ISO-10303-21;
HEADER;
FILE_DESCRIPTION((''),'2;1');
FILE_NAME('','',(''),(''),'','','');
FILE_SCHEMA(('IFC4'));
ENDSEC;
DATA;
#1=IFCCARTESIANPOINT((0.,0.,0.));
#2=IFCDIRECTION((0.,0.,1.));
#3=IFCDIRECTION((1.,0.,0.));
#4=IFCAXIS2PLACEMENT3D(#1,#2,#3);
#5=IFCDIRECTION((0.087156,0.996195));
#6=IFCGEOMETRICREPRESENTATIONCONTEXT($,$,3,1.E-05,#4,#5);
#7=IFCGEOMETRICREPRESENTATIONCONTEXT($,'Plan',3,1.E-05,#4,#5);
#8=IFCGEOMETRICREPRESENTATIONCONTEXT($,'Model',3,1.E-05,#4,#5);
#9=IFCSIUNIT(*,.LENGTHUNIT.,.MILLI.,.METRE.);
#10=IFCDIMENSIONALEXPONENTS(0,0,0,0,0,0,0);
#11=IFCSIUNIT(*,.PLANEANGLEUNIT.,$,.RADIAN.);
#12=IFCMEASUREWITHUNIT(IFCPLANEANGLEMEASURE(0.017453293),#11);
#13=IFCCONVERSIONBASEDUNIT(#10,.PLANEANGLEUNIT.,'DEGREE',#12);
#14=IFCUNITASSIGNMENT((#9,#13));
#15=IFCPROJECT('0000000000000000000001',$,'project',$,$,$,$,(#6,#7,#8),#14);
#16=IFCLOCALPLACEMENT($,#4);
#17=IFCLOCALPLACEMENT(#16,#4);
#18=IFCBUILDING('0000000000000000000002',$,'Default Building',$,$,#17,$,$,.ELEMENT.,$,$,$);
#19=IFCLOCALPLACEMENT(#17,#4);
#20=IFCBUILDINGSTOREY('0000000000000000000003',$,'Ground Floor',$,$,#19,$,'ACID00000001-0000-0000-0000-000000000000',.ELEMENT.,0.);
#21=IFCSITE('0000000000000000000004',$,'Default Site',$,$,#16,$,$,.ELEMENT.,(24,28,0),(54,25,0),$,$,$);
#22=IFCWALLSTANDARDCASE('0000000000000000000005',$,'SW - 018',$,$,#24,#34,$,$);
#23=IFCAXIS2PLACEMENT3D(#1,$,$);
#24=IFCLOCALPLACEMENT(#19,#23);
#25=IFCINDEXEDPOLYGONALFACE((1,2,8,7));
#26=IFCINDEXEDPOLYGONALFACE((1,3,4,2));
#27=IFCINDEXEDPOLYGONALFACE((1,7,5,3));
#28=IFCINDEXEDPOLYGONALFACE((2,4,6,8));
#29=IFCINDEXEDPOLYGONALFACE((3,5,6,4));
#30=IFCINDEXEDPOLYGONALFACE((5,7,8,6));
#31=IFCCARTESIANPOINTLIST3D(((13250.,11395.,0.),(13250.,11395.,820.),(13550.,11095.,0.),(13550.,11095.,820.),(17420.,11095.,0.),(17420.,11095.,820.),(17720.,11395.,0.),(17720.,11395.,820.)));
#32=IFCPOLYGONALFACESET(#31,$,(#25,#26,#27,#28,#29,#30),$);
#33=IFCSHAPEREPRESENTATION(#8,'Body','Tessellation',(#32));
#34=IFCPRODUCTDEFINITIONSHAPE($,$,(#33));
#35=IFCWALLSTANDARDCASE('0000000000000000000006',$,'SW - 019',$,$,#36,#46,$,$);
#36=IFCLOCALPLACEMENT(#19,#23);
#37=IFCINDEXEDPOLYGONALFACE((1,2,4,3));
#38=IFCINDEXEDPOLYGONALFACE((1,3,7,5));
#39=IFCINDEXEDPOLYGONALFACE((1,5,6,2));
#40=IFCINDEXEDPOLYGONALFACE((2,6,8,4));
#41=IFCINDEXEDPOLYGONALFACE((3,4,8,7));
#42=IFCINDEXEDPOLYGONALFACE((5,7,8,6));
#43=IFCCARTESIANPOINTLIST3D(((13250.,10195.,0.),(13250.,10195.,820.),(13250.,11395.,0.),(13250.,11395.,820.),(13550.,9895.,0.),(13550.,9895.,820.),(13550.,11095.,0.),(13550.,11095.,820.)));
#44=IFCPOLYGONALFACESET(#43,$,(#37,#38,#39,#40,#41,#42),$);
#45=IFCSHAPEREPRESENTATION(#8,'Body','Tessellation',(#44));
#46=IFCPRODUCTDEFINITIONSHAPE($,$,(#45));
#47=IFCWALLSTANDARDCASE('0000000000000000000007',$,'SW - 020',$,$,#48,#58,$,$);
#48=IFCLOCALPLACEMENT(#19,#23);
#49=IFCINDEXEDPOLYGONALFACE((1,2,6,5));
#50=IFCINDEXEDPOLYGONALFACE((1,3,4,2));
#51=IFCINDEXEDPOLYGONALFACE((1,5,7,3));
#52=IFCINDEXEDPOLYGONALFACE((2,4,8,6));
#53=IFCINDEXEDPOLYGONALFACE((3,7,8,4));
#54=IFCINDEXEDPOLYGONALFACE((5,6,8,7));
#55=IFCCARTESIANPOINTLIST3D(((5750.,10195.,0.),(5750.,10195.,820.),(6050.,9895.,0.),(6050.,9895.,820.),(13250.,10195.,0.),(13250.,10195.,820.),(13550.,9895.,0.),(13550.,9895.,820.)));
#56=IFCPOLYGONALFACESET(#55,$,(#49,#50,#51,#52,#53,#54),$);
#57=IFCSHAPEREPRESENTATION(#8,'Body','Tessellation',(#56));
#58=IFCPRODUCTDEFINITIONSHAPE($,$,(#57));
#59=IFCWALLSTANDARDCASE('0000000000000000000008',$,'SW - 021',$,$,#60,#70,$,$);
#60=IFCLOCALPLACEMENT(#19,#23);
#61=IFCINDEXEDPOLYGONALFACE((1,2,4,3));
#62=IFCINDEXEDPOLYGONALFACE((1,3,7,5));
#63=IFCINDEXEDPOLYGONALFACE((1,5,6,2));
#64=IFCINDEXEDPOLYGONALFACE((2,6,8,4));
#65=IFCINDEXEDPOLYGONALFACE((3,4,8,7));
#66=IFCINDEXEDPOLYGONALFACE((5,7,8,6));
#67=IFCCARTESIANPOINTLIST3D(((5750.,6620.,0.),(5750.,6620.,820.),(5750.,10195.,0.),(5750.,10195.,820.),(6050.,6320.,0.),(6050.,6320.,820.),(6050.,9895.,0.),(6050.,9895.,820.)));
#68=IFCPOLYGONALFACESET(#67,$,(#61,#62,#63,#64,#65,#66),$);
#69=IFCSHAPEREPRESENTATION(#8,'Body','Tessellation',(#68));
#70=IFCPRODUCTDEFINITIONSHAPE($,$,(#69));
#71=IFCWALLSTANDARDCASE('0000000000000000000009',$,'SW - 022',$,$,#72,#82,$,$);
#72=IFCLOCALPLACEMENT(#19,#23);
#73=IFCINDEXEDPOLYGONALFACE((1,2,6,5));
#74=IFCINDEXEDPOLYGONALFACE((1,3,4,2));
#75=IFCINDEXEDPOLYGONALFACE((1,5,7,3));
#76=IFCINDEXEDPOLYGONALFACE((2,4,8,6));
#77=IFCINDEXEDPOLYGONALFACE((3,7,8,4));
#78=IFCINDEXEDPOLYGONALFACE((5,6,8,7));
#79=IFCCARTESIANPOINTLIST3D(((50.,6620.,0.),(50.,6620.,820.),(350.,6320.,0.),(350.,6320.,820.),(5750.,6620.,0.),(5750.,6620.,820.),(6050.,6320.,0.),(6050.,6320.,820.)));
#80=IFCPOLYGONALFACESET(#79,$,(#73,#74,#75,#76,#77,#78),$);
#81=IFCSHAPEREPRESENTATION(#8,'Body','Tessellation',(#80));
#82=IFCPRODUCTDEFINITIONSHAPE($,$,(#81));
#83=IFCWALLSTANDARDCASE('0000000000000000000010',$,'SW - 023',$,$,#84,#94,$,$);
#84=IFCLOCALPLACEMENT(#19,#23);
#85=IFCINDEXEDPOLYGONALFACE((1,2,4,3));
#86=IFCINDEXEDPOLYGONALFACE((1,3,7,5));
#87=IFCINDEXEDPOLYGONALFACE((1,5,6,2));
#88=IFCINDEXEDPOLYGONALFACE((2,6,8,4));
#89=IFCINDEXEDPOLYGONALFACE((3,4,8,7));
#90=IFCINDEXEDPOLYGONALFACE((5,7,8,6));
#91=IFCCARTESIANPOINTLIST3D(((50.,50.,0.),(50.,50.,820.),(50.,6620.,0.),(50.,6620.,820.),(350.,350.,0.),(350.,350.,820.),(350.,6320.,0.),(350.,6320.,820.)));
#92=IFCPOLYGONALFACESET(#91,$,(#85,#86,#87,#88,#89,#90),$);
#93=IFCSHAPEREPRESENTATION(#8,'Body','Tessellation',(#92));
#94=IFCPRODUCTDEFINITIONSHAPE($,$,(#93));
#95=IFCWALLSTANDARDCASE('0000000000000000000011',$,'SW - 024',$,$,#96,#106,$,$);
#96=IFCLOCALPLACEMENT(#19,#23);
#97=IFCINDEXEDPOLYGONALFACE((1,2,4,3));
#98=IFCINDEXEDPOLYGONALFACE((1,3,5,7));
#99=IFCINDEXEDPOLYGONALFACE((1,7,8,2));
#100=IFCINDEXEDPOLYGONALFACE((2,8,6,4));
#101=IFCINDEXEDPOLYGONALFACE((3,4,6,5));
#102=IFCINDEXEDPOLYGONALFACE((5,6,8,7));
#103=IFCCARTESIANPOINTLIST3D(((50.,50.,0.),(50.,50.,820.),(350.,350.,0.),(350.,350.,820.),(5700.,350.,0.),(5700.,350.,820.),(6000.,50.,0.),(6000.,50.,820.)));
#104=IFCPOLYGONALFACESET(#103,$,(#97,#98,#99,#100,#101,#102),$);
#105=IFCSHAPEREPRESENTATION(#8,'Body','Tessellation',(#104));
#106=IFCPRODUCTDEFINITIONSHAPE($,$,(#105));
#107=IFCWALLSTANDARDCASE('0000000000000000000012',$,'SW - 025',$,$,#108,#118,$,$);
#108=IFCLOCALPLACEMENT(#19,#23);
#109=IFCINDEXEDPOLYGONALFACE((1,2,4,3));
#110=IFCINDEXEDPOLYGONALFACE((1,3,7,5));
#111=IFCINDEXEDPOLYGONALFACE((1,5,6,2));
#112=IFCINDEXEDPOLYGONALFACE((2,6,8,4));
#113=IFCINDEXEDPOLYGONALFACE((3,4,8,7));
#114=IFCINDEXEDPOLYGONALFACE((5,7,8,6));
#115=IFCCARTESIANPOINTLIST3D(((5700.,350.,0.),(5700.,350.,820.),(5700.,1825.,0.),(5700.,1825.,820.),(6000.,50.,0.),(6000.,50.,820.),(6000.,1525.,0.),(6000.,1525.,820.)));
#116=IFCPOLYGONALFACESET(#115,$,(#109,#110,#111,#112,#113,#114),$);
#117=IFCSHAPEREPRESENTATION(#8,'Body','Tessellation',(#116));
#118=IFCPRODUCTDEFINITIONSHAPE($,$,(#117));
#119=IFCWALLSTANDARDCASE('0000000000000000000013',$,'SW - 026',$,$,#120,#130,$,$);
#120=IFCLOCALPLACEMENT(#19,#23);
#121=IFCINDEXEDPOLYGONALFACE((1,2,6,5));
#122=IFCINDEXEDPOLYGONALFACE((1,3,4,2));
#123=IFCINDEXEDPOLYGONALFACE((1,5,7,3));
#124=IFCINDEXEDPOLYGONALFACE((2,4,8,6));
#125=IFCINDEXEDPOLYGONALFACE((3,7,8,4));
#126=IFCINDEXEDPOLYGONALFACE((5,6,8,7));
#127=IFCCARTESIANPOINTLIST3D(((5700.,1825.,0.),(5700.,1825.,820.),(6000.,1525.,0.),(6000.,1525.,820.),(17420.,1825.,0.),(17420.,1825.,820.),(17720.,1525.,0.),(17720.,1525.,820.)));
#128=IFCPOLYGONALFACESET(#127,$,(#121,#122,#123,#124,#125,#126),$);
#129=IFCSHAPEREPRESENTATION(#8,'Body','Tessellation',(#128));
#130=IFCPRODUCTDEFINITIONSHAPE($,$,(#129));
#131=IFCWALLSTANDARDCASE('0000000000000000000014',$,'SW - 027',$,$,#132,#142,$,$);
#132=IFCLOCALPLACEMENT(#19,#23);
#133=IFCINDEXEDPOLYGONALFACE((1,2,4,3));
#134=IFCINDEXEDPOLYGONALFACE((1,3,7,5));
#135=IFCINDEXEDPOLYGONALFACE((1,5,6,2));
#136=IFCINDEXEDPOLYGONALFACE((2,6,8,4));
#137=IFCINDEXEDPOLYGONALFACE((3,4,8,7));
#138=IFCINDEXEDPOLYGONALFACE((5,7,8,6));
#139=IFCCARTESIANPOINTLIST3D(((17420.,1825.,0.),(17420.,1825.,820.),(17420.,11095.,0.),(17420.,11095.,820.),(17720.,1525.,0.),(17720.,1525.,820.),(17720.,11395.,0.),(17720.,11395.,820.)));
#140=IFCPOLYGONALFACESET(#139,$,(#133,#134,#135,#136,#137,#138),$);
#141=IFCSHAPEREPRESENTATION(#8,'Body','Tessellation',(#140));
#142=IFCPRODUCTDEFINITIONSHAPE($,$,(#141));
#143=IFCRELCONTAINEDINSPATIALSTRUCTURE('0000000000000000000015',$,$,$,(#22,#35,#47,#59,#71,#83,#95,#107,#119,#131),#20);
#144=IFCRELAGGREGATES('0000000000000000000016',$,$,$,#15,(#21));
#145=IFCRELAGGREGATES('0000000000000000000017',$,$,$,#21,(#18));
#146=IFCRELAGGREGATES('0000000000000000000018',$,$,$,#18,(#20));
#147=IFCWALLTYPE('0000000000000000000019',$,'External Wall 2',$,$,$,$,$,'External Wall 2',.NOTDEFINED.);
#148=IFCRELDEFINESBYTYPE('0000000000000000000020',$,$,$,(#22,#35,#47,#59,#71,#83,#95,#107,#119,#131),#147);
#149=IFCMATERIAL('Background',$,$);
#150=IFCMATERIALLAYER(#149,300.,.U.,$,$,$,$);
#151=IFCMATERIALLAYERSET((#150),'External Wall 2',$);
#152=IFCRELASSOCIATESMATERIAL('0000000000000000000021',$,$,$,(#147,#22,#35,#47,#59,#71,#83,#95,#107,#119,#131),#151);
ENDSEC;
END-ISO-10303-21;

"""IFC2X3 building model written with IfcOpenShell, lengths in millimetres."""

from ifc_helpers import new_model, entity, si_unit, converted_unit, direction, frame, origin_with_axes, place, context, project, spatial, polyline, outline, extrude, material, layer, layer_set, layer_usage, type_object, element, save


model = new_model("IFC2X3")

# Units and contexts
context_of_model = context(None, 3, precision=1e-05, world=origin_with_axes(), true_north=direction((0.087156, 0.996195)))
plan_context = context("Plan", 3, precision=1e-05, world=origin_with_axes(), true_north=direction((0.087156, 0.996195)))
model_context = context("Model", 3, precision=1e-05, world=origin_with_axes(), true_north=direction((0.087156, 0.996195)))
ifc_project = project(units=[si_unit("LENGTHUNIT", "METRE", prefix="MILLI"), converted_unit("PLANEANGLEUNIT", "DEGREE", entity("IfcPlaneAngleMeasure", 0.017453293), si_unit("PLANEANGLEUNIT", "RADIAN"), dimensions=[0, 0, 0, 0, 0, 0, 0])], contexts=[context_of_model, plan_context, model_context])

# Site, building, storey
site_placement = place(None, origin_with_axes())
site = spatial("IfcSite", under=ifc_project, at=site_placement, Name="Default Site", CompositionType="ELEMENT", RefLatitude=(24, 28, 0), RefLongitude=(54, 25, 0))
building_placement = place(site_placement, origin_with_axes())
building = spatial("IfcBuilding", under=site, at=building_placement, Name="Default Building", CompositionType="ELEMENT")
storey_placement = place(building_placement, origin_with_axes())
storey = spatial("IfcBuildingStorey", under=building, at=storey_placement, Name="Ground Floor", LongName="ACID00000001-0000-0000-0000-000000000000", CompositionType="ELEMENT", Elevation=0.0)

# Walls
ifc_material = material(Name="Background")
ifc_layer = layer(ifc_material, 300.0, ventilated="UNKNOWN")
ifc_layer_set = layer_set([ifc_layer], Name="External Wall 2")
ifc_layer_usage_1 = layer_usage(ifc_layer_set, "AXIS2", "POSITIVE", 0.0)
wall_type = type_object("IfcWallType", Name="External Wall 2", ElementType="External Wall 2", PredefinedType="NOTDEFINED", material=ifc_layer_set)
wall_1_placement = place(storey_placement, frame((17720.0, 11395.0, 0.0), z_axis=(0.0, 0.0, 1.0), x_axis=(-1.0, 0.0, 0.0)))
element("IfcWallStandardCase", 1, at=wall_1_placement, inside=storey, type_object=wall_type, material=ifc_layer_usage_1, Name="SW - 018", context=model_context, shape_type="SweptSolid", body=[
    extrude(outline(polyline([(0.0, 0.0), (4470.0, 0.0), (4170.0, 300.0), (300.0, 300.0), (0.0, 0.0)])), origin_with_axes(), (0.0, 0.0, 1.0), 820.0),
])
ifc_layer_usage_2 = layer_usage(ifc_layer_set, "AXIS2", "POSITIVE", 0.0)
wall_2_placement = place(storey_placement, frame((13250.0, 11395.0, 0.0), z_axis=(0.0, 0.0, 1.0), x_axis=(0.0, -1.0, 0.0)))
element("IfcWallStandardCase", 2, at=wall_2_placement, inside=storey, type_object=wall_type, material=ifc_layer_usage_2, Name="SW - 019", context=model_context, shape_type="SweptSolid", body=[
    extrude(outline(polyline([(0.0, 0.0), (1200.0, 0.0), (1500.0, 300.0), (300.0, 300.0), (0.0, 0.0)])), origin_with_axes(), (0.0, 0.0, 1.0), 820.0),
])
ifc_layer_usage_3 = layer_usage(ifc_layer_set, "AXIS2", "POSITIVE", 0.0)
wall_3_placement = place(storey_placement, frame((13250.0, 10195.0, 0.0), z_axis=(0.0, 0.0, 1.0), x_axis=(-1.0, 0.0, 0.0)))
element("IfcWallStandardCase", 3, at=wall_3_placement, inside=storey, type_object=wall_type, material=ifc_layer_usage_3, Name="SW - 020", context=model_context, shape_type="SweptSolid", body=[
    extrude(outline(polyline([(0.0, 0.0), (7500.0, 0.0), (7200.0, 300.0), (-300.0, 300.0), (0.0, 0.0)])), origin_with_axes(), (0.0, 0.0, 1.0), 820.0),
])
ifc_layer_usage_4 = layer_usage(ifc_layer_set, "AXIS2", "POSITIVE", 0.0)
wall_4_placement = place(storey_placement, frame((5750.0, 10195.0, 0.0), z_axis=(0.0, 0.0, 1.0), x_axis=(0.0, -1.0, 0.0)))
element("IfcWallStandardCase", 4, at=wall_4_placement, inside=storey, type_object=wall_type, material=ifc_layer_usage_4, Name="SW - 021", context=model_context, shape_type="SweptSolid", body=[
    extrude(outline(polyline([(0.0, 0.0), (3575.0, 0.0), (3875.0, 300.0), (300.0, 300.0), (0.0, 0.0)])), origin_with_axes(), (0.0, 0.0, 1.0), 820.0),
])
ifc_layer_usage_5 = layer_usage(ifc_layer_set, "AXIS2", "POSITIVE", 0.0)
wall_5_placement = place(storey_placement, frame((5750.0, 6620.0, 0.0), z_axis=(0.0, 0.0, 1.0), x_axis=(-1.0, 0.0, 0.0)))
element("IfcWallStandardCase", 5, at=wall_5_placement, inside=storey, type_object=wall_type, material=ifc_layer_usage_5, Name="SW - 022", context=model_context, shape_type="SweptSolid", body=[
    extrude(outline(polyline([(0.0, 0.0), (5700.0, 0.0), (5400.0, 300.0), (-300.0, 300.0), (0.0, 0.0)])), origin_with_axes(), (0.0, 0.0, 1.0), 820.0),
])
ifc_layer_usage_6 = layer_usage(ifc_layer_set, "AXIS2", "POSITIVE", 0.0)
wall_6_placement = place(storey_placement, frame((50.0, 6620.0, 0.0), z_axis=(0.0, 0.0, 1.0), x_axis=(0.0, -1.0, 0.0)))
element("IfcWallStandardCase", 6, at=wall_6_placement, inside=storey, type_object=wall_type, material=ifc_layer_usage_6, Name="SW - 023", context=model_context, shape_type="SweptSolid", body=[
    extrude(outline(polyline([(0.0, 0.0), (6570.0, 0.0), (6270.0, 300.0), (300.0, 300.0), (0.0, 0.0)])), origin_with_axes(), (0.0, 0.0, 1.0), 820.0),
])
ifc_layer_usage_7 = layer_usage(ifc_layer_set, "AXIS2", "POSITIVE", 0.0)
wall_7_placement = place(storey_placement, frame((50.0, 50.0, 0.0), z_axis=(0.0, 0.0, 1.0), x_axis=(1.0, 0.0, 0.0)))
element("IfcWallStandardCase", 7, at=wall_7_placement, inside=storey, type_object=wall_type, material=ifc_layer_usage_7, Name="SW - 024", context=model_context, shape_type="SweptSolid", body=[
    extrude(outline(polyline([(0.0, 0.0), (5950.0, 0.0), (5650.0, 300.0), (300.0, 300.0), (0.0, 0.0)])), origin_with_axes(), (0.0, 0.0, 1.0), 820.0),
])
ifc_layer_usage_8 = layer_usage(ifc_layer_set, "AXIS2", "POSITIVE", 0.0)
wall_8_placement = place(storey_placement, frame((6000.0, 50.0, 0.0), z_axis=(0.0, 0.0, 1.0), x_axis=(0.0, 1.0, 0.0)))
element("IfcWallStandardCase", 8, at=wall_8_placement, inside=storey, type_object=wall_type, material=ifc_layer_usage_8, Name="SW - 025", context=model_context, shape_type="SweptSolid", body=[
    extrude(outline(polyline([(0.0, 0.0), (1475.0, 0.0), (1775.0, 300.0), (300.0, 300.0), (0.0, 0.0)])), origin_with_axes(), (0.0, 0.0, 1.0), 820.0),
])
ifc_layer_usage_9 = layer_usage(ifc_layer_set, "AXIS2", "POSITIVE", 0.0)
wall_9_placement = place(storey_placement, frame((6000.0, 1525.0, 0.0), z_axis=(0.0, 0.0, 1.0), x_axis=(1.0, 0.0, 0.0)))
element("IfcWallStandardCase", 9, at=wall_9_placement, inside=storey, type_object=wall_type, material=ifc_layer_usage_9, Name="SW - 026", context=model_context, shape_type="SweptSolid", body=[
    extrude(outline(polyline([(0.0, 0.0), (11720.0, 0.0), (11420.0, 300.0), (-300.0, 300.0), (0.0, 0.0)])), origin_with_axes(), (0.0, 0.0, 1.0), 820.0),
])
ifc_layer_usage_10 = layer_usage(ifc_layer_set, "AXIS2", "POSITIVE", 0.0)
wall_10_placement = place(storey_placement, frame((17720.0, 1525.0, 0.0), z_axis=(0.0, 0.0, 1.0), x_axis=(0.0, 1.0, 0.0)))
element("IfcWallStandardCase", 10, at=wall_10_placement, inside=storey, type_object=wall_type, material=ifc_layer_usage_10, Name="SW - 027", context=model_context, shape_type="SweptSolid", body=[
    extrude(outline(polyline([(0.0, 0.0), (9870.0, 0.0), (9570.0, 300.0), (300.0, 300.0), (0.0, 0.0)])), origin_with_axes(), (0.0, 0.0, 1.0), 820.0),
])

save(model, "model.ifc")
